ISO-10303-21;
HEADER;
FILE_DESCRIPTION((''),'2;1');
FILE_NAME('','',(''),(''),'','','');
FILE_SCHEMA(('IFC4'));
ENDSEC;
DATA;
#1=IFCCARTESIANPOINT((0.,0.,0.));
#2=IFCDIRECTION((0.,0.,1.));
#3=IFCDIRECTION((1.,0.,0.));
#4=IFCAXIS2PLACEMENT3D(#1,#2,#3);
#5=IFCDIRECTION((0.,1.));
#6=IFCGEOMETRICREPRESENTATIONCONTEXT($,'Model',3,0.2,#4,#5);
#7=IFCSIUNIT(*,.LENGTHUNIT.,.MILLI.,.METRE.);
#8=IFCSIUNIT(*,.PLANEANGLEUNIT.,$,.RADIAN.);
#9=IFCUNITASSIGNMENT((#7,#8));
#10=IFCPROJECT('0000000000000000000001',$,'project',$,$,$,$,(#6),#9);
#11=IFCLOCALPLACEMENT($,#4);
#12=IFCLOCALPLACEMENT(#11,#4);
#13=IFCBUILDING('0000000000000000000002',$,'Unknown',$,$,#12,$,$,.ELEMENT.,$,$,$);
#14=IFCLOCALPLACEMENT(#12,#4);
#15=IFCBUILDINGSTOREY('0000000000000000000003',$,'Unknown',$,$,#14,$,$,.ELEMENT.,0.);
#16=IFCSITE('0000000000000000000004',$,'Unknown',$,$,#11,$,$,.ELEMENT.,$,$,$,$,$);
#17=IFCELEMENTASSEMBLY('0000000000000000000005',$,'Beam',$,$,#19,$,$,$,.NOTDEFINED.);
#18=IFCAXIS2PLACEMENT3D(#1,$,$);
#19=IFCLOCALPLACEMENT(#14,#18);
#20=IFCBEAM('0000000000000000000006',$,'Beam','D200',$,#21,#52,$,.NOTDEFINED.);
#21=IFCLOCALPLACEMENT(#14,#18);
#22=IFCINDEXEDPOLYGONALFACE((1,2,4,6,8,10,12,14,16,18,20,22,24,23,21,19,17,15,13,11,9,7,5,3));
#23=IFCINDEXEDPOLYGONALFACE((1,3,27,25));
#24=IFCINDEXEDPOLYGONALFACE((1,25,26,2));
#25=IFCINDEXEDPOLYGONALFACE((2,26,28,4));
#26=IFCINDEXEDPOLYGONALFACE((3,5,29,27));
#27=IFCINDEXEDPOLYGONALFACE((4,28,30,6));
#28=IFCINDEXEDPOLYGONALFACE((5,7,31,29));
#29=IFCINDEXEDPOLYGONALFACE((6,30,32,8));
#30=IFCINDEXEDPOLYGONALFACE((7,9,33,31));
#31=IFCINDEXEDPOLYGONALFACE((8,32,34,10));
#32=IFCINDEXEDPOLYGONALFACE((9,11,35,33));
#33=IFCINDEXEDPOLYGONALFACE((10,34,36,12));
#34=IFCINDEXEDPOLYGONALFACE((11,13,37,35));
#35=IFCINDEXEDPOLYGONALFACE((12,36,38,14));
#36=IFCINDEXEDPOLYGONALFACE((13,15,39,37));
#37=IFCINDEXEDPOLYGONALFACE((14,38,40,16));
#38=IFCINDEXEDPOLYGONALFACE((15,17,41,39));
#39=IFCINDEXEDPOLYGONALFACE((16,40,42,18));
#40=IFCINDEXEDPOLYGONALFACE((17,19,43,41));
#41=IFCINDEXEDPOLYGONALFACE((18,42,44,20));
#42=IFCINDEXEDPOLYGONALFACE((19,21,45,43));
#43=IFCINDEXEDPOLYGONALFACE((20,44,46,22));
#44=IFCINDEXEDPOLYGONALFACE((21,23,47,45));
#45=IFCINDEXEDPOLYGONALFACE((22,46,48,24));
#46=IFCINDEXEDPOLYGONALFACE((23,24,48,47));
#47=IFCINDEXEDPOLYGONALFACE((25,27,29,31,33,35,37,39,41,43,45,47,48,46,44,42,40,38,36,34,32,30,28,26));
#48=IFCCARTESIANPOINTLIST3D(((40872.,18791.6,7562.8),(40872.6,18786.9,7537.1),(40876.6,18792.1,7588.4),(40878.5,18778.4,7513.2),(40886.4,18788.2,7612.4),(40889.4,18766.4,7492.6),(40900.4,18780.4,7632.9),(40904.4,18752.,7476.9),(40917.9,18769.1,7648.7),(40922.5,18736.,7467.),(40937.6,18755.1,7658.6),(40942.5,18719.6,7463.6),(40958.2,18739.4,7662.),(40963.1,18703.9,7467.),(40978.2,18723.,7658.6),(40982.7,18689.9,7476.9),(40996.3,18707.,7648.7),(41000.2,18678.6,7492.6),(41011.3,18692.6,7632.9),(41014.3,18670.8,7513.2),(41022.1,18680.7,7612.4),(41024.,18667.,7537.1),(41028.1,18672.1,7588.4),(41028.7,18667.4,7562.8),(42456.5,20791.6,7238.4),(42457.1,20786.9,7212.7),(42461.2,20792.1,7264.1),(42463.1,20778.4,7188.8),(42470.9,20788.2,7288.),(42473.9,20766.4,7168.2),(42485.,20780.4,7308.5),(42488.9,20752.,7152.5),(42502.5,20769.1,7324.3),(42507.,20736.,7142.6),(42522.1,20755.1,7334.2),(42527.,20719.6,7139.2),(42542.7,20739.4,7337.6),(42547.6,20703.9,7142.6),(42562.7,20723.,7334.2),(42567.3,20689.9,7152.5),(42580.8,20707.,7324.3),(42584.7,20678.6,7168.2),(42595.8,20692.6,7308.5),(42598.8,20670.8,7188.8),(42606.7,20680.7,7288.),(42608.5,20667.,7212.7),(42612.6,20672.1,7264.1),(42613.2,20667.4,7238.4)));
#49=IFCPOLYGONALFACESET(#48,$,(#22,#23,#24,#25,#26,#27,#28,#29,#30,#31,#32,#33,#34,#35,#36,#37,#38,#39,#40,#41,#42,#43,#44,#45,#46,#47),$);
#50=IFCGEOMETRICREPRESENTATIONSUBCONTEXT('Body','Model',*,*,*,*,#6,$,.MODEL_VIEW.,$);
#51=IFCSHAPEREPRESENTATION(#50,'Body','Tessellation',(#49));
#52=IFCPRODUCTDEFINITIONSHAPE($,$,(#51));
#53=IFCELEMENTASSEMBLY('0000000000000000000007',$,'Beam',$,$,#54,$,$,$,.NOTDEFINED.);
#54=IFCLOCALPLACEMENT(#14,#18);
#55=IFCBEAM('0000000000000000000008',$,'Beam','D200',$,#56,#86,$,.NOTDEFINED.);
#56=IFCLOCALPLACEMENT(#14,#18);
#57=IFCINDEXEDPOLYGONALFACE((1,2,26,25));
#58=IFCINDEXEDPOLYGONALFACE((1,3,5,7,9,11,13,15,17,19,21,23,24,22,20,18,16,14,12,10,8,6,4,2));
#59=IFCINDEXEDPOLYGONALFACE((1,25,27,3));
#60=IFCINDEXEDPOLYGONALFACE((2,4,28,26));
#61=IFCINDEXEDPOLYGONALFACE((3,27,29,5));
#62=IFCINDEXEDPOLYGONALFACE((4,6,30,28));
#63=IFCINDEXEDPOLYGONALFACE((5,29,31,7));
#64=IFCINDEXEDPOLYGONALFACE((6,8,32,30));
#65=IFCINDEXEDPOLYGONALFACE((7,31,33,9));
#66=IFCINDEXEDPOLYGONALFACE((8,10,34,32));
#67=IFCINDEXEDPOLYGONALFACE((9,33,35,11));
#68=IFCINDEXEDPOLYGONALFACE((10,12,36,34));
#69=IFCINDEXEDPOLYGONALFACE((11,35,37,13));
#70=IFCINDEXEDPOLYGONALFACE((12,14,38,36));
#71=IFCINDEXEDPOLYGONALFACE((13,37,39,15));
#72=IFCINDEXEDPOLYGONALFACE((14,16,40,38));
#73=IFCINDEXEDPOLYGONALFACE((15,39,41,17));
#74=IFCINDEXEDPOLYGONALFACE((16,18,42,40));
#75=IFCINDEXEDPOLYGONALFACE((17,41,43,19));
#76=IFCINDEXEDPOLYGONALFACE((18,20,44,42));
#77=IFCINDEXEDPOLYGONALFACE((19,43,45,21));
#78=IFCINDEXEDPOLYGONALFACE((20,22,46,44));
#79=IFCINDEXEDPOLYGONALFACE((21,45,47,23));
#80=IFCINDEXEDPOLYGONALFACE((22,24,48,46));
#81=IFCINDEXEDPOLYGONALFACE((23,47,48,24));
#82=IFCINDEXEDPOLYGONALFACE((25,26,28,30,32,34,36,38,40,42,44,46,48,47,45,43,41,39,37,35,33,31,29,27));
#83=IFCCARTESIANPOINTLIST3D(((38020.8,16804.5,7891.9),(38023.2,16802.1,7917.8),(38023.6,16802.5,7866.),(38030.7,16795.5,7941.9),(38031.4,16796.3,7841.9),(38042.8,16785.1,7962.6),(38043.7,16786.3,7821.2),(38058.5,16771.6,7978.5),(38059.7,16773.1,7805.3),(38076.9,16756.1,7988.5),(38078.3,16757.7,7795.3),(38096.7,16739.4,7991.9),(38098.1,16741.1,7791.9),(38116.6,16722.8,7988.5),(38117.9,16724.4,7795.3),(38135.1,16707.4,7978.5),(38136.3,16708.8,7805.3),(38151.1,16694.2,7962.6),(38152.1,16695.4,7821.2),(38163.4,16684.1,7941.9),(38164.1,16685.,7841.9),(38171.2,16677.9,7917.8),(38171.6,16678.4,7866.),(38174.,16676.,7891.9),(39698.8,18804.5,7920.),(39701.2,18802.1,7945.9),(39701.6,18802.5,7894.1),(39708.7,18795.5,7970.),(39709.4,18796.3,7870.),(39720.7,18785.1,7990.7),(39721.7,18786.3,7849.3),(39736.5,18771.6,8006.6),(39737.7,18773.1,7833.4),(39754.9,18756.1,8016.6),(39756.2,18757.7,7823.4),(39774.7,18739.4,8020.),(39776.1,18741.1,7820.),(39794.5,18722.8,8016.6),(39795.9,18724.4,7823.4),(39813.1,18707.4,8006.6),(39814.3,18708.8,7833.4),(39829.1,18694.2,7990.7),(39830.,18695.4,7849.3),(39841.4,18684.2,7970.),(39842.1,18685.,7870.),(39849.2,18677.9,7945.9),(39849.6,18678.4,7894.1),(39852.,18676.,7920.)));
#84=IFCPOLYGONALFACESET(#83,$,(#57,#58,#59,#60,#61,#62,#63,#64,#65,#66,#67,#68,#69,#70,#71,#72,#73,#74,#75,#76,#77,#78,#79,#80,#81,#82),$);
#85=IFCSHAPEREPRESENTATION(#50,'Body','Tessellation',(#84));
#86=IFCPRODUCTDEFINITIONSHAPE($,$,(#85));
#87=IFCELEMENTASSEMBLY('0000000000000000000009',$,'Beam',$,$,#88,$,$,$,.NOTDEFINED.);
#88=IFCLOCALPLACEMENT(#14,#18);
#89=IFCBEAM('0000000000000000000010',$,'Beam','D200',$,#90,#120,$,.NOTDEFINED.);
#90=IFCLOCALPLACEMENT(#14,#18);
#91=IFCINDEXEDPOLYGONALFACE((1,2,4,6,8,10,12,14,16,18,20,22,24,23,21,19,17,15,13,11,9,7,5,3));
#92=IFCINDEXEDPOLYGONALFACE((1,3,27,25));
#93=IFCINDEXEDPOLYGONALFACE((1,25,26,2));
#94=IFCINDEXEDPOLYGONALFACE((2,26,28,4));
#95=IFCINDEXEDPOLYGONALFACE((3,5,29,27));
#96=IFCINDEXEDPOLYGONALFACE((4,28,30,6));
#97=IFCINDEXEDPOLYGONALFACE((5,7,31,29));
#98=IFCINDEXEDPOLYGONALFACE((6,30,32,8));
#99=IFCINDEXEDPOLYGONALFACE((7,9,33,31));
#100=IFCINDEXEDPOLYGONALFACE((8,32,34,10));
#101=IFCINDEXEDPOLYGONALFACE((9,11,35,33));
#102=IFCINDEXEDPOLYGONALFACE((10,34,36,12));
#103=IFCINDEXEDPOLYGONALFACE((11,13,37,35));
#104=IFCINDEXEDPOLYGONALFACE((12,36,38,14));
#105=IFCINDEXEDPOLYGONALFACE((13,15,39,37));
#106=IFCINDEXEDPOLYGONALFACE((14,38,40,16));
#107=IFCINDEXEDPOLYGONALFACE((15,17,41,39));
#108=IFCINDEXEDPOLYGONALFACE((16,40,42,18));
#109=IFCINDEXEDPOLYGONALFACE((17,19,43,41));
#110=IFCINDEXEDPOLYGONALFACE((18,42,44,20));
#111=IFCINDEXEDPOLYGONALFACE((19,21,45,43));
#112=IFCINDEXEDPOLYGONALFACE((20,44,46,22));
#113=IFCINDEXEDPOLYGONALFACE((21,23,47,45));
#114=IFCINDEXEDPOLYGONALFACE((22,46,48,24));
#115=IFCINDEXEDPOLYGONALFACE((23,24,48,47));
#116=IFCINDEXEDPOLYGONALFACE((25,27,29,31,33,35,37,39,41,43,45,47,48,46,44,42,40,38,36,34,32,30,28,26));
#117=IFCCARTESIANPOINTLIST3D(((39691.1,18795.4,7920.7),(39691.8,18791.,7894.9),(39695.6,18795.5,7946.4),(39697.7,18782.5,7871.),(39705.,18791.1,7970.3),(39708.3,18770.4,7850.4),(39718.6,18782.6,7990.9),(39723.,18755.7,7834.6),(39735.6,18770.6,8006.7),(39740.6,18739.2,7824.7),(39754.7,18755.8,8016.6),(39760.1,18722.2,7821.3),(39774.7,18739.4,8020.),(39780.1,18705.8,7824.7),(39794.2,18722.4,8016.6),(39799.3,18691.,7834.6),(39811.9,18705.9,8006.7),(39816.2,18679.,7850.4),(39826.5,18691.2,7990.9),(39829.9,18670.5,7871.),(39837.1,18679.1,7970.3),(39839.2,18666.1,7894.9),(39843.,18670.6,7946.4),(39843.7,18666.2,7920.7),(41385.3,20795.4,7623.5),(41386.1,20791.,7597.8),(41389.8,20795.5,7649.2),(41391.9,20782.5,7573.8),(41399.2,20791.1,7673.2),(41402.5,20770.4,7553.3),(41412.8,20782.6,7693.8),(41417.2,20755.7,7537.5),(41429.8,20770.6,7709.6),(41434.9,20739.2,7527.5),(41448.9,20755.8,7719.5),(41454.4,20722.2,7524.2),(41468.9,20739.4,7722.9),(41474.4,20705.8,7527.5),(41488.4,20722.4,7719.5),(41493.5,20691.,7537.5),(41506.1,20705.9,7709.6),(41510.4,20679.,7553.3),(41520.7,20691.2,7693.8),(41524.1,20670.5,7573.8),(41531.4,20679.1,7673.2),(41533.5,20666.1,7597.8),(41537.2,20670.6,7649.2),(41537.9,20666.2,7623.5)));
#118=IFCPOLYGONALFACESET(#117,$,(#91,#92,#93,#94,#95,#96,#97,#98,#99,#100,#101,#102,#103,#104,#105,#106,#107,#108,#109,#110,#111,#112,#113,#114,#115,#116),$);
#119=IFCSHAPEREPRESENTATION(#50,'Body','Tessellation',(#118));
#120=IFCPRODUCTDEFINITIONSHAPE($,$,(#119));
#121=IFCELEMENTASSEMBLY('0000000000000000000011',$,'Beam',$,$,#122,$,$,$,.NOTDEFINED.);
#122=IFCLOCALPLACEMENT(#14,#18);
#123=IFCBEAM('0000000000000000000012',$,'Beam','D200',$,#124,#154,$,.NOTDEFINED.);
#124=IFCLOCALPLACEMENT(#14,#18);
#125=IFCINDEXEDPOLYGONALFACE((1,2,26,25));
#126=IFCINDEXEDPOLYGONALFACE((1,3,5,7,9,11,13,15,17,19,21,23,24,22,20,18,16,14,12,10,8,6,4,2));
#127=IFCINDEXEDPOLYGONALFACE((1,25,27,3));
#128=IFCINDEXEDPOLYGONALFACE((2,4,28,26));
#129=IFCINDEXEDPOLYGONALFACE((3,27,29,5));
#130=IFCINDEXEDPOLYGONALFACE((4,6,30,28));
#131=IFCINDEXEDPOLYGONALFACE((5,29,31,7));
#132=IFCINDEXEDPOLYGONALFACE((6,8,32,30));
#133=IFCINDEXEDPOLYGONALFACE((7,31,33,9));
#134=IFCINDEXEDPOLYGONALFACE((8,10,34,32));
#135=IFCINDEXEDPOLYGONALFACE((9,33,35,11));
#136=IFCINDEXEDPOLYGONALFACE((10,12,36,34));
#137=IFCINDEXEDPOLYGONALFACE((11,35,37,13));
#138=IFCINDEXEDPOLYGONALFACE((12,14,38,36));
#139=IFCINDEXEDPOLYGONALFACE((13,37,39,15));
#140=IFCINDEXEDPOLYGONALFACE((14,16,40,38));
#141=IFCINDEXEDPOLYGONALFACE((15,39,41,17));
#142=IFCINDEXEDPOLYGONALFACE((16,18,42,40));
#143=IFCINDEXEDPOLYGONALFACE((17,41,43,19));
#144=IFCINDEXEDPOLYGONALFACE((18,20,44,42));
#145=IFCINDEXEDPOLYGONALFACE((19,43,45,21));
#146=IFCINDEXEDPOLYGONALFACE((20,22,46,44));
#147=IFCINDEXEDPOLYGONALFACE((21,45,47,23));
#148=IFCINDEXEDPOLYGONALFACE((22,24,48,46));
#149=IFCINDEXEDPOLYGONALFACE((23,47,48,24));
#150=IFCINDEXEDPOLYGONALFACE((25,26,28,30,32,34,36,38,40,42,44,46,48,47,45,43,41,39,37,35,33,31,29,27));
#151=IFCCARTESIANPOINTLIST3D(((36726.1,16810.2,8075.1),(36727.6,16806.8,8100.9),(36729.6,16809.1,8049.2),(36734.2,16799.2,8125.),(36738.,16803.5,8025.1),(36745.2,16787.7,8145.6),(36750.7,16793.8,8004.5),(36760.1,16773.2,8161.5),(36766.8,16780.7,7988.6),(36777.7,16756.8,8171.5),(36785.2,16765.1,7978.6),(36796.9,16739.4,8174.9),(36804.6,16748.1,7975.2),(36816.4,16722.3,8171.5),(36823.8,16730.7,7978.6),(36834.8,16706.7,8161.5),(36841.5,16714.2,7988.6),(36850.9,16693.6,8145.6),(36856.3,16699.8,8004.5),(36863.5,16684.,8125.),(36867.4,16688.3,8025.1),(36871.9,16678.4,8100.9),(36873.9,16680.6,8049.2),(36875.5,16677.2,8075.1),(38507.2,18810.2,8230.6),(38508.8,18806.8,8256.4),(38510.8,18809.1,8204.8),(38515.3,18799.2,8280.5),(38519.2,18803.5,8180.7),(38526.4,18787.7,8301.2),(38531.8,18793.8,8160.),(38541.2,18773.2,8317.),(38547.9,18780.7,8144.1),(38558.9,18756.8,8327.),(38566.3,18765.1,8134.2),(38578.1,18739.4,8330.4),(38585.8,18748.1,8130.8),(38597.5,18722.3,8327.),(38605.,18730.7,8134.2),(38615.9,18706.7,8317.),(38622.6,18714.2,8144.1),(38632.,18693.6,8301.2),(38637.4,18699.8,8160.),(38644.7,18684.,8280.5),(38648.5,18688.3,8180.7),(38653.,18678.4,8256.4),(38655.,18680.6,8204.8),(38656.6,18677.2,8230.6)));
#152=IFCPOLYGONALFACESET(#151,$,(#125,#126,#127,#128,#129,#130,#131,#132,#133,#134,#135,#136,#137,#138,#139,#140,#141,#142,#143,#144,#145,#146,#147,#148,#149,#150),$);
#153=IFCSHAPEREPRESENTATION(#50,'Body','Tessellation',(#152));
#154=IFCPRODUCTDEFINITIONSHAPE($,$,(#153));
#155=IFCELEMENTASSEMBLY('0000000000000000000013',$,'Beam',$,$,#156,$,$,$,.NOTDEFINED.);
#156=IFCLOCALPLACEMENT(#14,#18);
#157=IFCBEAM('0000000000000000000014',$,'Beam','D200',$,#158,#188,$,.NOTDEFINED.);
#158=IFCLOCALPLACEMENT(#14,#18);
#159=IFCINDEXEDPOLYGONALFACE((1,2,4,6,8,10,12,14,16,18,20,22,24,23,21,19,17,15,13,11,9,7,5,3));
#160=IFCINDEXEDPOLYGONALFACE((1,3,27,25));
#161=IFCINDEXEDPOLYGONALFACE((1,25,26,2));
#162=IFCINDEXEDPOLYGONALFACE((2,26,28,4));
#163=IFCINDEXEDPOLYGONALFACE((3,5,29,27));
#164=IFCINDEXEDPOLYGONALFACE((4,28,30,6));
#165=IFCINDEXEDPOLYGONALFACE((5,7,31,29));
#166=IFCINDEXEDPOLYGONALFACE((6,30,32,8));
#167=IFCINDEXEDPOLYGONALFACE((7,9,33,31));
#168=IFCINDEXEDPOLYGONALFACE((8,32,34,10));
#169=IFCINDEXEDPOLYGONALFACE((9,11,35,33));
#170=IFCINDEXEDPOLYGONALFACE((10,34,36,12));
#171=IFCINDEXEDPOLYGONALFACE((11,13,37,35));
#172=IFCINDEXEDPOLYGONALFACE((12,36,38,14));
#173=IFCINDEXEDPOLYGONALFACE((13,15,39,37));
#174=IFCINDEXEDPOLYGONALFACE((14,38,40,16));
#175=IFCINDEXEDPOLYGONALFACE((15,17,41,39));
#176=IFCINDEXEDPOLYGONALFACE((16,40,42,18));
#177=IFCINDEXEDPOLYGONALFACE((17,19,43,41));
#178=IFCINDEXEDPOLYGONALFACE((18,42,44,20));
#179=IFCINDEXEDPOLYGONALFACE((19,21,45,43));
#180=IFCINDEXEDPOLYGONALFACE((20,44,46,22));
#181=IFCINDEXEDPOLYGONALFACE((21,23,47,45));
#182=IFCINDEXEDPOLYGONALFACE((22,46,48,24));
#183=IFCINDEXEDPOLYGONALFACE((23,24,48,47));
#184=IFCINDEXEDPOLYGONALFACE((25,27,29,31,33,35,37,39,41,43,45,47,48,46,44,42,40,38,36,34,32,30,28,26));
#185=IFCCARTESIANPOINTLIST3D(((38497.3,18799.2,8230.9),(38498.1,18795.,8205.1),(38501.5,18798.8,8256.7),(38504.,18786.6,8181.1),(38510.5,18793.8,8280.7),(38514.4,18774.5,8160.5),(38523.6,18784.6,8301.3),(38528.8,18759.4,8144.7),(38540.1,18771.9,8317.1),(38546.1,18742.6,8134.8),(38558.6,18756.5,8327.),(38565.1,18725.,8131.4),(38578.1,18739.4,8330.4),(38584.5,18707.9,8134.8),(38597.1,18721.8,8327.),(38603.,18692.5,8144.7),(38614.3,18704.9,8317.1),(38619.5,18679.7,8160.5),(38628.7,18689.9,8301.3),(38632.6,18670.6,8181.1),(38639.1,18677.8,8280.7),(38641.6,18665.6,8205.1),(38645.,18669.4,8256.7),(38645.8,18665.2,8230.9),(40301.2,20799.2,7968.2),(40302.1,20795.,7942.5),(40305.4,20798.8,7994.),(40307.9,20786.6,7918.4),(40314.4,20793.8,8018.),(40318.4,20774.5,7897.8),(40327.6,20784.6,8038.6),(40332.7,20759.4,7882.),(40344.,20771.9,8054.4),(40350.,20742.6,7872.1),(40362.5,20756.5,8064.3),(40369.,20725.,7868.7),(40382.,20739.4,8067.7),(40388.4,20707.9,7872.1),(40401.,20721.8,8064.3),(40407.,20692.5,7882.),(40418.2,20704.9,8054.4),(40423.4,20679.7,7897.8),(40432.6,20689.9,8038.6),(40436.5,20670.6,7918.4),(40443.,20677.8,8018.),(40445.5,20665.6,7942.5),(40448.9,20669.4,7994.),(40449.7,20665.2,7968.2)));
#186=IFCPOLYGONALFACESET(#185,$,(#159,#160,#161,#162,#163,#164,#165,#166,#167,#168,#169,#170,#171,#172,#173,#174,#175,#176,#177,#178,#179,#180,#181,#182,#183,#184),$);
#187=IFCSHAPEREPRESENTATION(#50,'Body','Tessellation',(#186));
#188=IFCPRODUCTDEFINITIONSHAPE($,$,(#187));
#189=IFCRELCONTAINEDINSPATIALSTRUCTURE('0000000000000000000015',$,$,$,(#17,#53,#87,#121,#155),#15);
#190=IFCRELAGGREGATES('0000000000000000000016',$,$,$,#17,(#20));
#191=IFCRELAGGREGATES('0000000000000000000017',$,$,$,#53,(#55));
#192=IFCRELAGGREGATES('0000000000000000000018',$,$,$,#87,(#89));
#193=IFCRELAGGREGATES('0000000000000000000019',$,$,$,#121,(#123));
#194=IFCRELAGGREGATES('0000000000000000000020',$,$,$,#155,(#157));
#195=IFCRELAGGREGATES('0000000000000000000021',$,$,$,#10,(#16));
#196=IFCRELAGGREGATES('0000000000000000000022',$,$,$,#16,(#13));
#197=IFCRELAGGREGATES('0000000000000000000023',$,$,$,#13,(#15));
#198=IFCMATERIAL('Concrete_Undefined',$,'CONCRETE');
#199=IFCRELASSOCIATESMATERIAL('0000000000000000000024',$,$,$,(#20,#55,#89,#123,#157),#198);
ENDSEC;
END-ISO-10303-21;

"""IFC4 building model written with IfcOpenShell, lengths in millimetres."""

from ifc_helpers import new_model, si_unit, direction, frame, origin_with_axes, place, context, subcontext, project, spatial, line, indexed_curve, outline, extrude, material, element, aggregate, save


model = new_model("IFC4")

# Units and contexts
model_context = context("Model", 3, precision=0.2, world=origin_with_axes(), true_north=direction((0.0, 1.0)))
body_context = subcontext(model_context, "Body", "Model", "MODEL_VIEW")
ifc_project = project(units=[si_unit("LENGTHUNIT", "METRE", prefix="MILLI"), si_unit("PLANEANGLEUNIT", "RADIAN")], contexts=[model_context])

# Site, building, storey
site_placement = place(None, origin_with_axes())
site = spatial("IfcSite", under=ifc_project, at=site_placement, Name="Unknown", CompositionType="ELEMENT")
building_placement = place(site_placement, origin_with_axes())
building = spatial("IfcBuilding", under=site, at=building_placement, Name="Unknown", CompositionType="ELEMENT")
storey_placement = place(building_placement, origin_with_axes())
storey = spatial("IfcBuildingStorey", under=building, at=storey_placement, Name="Unknown", CompositionType="ELEMENT", Elevation=0.0)

# Element assemblies, beams
assembly_1_placement = place(storey_placement, frame((42534.9, 20729.5, 7238.4), z_axis=(-0.783818, 0.620991, 0.0), x_axis=(-0.616033, -0.777559, 0.126116)))
assembly_1 = element("IfcElementAssembly", 1, at=assembly_1_placement, inside=storey, Name="Beam", PredefinedType="NOTDEFINED")
ifc_material = material(Name="Concrete_Undefined", Category="CONCRETE")
beam_1_placement = place(assembly_1_placement, origin_with_axes())
beam_1 = element("IfcBeam", 2, at=beam_1_placement, material=ifc_material, Name="Beam", Description="D200", PredefinedType="NOTDEFINED", context=body_context, shape_type="SolidModel", body=[
    extrude(outline(indexed_curve([(100.0, 0.0), (96.6, 25.9), (86.6, 50.0), (70.7, 70.7), (50.0, 86.6), (25.9, 96.6), (0.0, 100.0), (-25.9, 96.6), (-50.0, 86.6), (-70.7, 70.7), (-86.6, 50.0), (-96.6, 25.9), (-100.0, 0.0), (-96.6, -25.9), (-86.6, -50.0), (-70.7, -70.7), (-50.0, -86.6), (-25.9, -96.6), (0.0, -100.0), (25.9, -96.6), (50.0, -86.6), (70.7, -70.7), (86.6, -50.0), (96.6, -25.9)], segments=[line(1, 2, 3, 4, 5, 6, 7, 8, 9, 10, 11, 12, 13, 14, 15, 16, 17, 18, 19, 20, 21, 22, 23, 24, 1)])), frame((0.0, 0.0, 0.0), z_axis=(-1.0, 0.0, 0.0), x_axis=(0.0, 0.0, 1.0)), (0.0, 0.0, -1.0), 2572.2),
])
aggregate(assembly_1, [beam_1])
assembly_2_placement = place(storey_placement, frame((39775.4, 18740.2, 7920.0), z_axis=(-0.766088, 0.642736, 0.0), x_axis=(-0.642698, -0.766044, -0.010779)))
assembly_2 = element("IfcElementAssembly", 3, at=assembly_2_placement, inside=storey, Name="Beam", PredefinedType="NOTDEFINED")
beam_2_placement = place(assembly_2_placement, origin_with_axes())
beam_2 = element("IfcBeam", 4, at=beam_2_placement, material=ifc_material, Name="Beam", Description="D200", PredefinedType="NOTDEFINED", context=body_context, shape_type="SolidModel", body=[
    extrude(outline(indexed_curve([(100.0, 0.0), (96.6, 25.9), (86.6, 50.0), (70.7, 70.7), (50.0, 86.6), (25.9, 96.6), (0.0, 100.0), (-25.9, 96.6), (-50.0, 86.6), (-70.7, 70.7), (-86.6, 50.0), (-96.6, 25.9), (-100.0, 0.0), (-96.6, -25.9), (-86.6, -50.0), (-70.7, -70.7), (-50.0, -86.6), (-25.9, -96.6), (0.0, -100.0), (25.9, -96.6), (50.0, -86.6), (70.7, -70.7), (86.6, -50.0), (96.6, -25.9)], segments=[line(1, 2, 3, 4, 5, 6, 7, 8, 9, 10, 11, 12, 13, 14, 15, 16, 17, 18, 19, 20, 21, 22, 23, 24, 1)])), frame((0.0, 0.0, 0.0), z_axis=(-1.0, 0.0, 0.0), x_axis=(0.0, 0.0, 1.0)), (0.0, 0.0, -1.0), 2610.8),
])
aggregate(assembly_2, [beam_2])
assembly_3_placement = place(storey_placement, frame((41461.6, 20730.8, 7623.5), z_axis=(-0.763025, 0.646369, 0.0), x_axis=(-0.642256, -0.758169, 0.112638)))
assembly_3 = element("IfcElementAssembly", 5, at=assembly_3_placement, inside=storey, Name="Beam", PredefinedType="NOTDEFINED")
beam_3_placement = place(assembly_3_placement, origin_with_axes())
beam_3 = element("IfcBeam", 6, at=beam_3_placement, material=ifc_material, Name="Beam", Description="D200", PredefinedType="NOTDEFINED", context=body_context, shape_type="SolidModel", body=[
    extrude(outline(indexed_curve([(100.0, 0.0), (96.6, 25.9), (86.6, 50.0), (70.7, 70.7), (50.0, 86.6), (25.9, 96.6), (0.0, 100.0), (-25.9, 96.6), (-50.0, 86.6), (-70.7, 70.7), (-86.6, 50.0), (-96.6, 25.9), (-100.0, 0.0), (-96.6, -25.9), (-86.6, -50.0), (-70.7, -70.7), (-50.0, -86.6), (-25.9, -96.6), (0.0, -100.0), (25.9, -96.6), (50.0, -86.6), (70.7, -70.7), (86.6, -50.0), (96.6, -25.9)], segments=[line(1, 2, 3, 4, 5, 6, 7, 8, 9, 10, 11, 12, 13, 14, 15, 16, 17, 18, 19, 20, 21, 22, 23, 24, 1)])), frame((0.0, 0.0, 0.0), z_axis=(-1.0, 0.0, 0.0), x_axis=(0.0, 0.0, 1.0)), (0.0, 0.0, -1.0), 2637.9),
])
aggregate(assembly_3, [beam_3])
assembly_4_placement = place(storey_placement, frame((38581.9, 18743.7, 8230.6), z_axis=(-0.746788, 0.665062, 0.0), x_axis=(-0.663944, -0.745532, -0.057978)))
assembly_4 = element("IfcElementAssembly", 7, at=assembly_4_placement, inside=storey, Name="Beam", PredefinedType="NOTDEFINED")
beam_4_placement = place(assembly_4_placement, origin_with_axes())
beam_4 = element("IfcBeam", 8, at=beam_4_placement, material=ifc_material, Name="Beam", Description="D200", PredefinedType="NOTDEFINED", context=body_context, shape_type="SolidModel", body=[
    extrude(outline(indexed_curve([(100.0, 0.0), (96.6, 25.9), (86.6, 50.0), (70.7, 70.7), (50.0, 86.6), (25.9, 96.6), (0.0, 100.0), (-25.9, 96.6), (-50.0, 86.6), (-70.7, 70.7), (-86.6, 50.0), (-96.6, 25.9), (-100.0, 0.0), (-96.6, -25.9), (-86.6, -50.0), (-70.7, -70.7), (-50.0, -86.6), (-25.9, -96.6), (0.0, -100.0), (25.9, -96.6), (50.0, -86.6), (70.7, -70.7), (86.6, -50.0), (96.6, -25.9)], segments=[line(1, 2, 3, 4, 5, 6, 7, 8, 9, 10, 11, 12, 13, 14, 15, 16, 17, 18, 19, 20, 21, 22, 23, 24, 1)])), frame((0.0, 0.0, 0.0), z_axis=(-1.0, 0.0, 0.0), x_axis=(0.0, 0.0, 1.0)), (0.0, 0.0, -1.0), 2682.6),
])
aggregate(assembly_4, [beam_4])
assembly_5_placement = place(storey_placement, frame((40375.5, 20732.2, 7968.2), z_axis=(-0.742568, 0.669771, 0.0), x_axis=(-0.666608, -0.739061, 0.09707)))
assembly_5 = element("IfcElementAssembly", 9, at=assembly_5_placement, inside=storey, Name="Beam", PredefinedType="NOTDEFINED")
beam_5_placement = place(assembly_5_placement, origin_with_axes())
beam_5 = element("IfcBeam", 10, at=beam_5_placement, material=ifc_material, Name="Beam", Description="D200", PredefinedType="NOTDEFINED", context=body_context, shape_type="SolidModel", body=[
    extrude(outline(indexed_curve([(100.0, 0.0), (96.6, 25.9), (86.6, 50.0), (70.7, 70.7), (50.0, 86.6), (25.9, 96.6), (0.0, 100.0), (-25.9, 96.6), (-50.0, 86.6), (-70.7, 70.7), (-86.6, 50.0), (-96.6, 25.9), (-100.0, 0.0), (-96.6, -25.9), (-86.6, -50.0), (-70.7, -70.7), (-50.0, -86.6), (-25.9, -96.6), (0.0, -100.0), (25.9, -96.6), (50.0, -86.6), (70.7, -70.7), (86.6, -50.0), (96.6, -25.9)], segments=[line(1, 2, 3, 4, 5, 6, 7, 8, 9, 10, 11, 12, 13, 14, 15, 16, 17, 18, 19, 20, 21, 22, 23, 24, 1)])), frame((0.0, 0.0, 0.0), z_axis=(-1.0, 0.0, 0.0), x_axis=(0.0, 0.0, 1.0)), (0.0, 0.0, -1.0), 2706.1),
])
aggregate(assembly_5, [beam_5])

save(model, "model.ifc")
